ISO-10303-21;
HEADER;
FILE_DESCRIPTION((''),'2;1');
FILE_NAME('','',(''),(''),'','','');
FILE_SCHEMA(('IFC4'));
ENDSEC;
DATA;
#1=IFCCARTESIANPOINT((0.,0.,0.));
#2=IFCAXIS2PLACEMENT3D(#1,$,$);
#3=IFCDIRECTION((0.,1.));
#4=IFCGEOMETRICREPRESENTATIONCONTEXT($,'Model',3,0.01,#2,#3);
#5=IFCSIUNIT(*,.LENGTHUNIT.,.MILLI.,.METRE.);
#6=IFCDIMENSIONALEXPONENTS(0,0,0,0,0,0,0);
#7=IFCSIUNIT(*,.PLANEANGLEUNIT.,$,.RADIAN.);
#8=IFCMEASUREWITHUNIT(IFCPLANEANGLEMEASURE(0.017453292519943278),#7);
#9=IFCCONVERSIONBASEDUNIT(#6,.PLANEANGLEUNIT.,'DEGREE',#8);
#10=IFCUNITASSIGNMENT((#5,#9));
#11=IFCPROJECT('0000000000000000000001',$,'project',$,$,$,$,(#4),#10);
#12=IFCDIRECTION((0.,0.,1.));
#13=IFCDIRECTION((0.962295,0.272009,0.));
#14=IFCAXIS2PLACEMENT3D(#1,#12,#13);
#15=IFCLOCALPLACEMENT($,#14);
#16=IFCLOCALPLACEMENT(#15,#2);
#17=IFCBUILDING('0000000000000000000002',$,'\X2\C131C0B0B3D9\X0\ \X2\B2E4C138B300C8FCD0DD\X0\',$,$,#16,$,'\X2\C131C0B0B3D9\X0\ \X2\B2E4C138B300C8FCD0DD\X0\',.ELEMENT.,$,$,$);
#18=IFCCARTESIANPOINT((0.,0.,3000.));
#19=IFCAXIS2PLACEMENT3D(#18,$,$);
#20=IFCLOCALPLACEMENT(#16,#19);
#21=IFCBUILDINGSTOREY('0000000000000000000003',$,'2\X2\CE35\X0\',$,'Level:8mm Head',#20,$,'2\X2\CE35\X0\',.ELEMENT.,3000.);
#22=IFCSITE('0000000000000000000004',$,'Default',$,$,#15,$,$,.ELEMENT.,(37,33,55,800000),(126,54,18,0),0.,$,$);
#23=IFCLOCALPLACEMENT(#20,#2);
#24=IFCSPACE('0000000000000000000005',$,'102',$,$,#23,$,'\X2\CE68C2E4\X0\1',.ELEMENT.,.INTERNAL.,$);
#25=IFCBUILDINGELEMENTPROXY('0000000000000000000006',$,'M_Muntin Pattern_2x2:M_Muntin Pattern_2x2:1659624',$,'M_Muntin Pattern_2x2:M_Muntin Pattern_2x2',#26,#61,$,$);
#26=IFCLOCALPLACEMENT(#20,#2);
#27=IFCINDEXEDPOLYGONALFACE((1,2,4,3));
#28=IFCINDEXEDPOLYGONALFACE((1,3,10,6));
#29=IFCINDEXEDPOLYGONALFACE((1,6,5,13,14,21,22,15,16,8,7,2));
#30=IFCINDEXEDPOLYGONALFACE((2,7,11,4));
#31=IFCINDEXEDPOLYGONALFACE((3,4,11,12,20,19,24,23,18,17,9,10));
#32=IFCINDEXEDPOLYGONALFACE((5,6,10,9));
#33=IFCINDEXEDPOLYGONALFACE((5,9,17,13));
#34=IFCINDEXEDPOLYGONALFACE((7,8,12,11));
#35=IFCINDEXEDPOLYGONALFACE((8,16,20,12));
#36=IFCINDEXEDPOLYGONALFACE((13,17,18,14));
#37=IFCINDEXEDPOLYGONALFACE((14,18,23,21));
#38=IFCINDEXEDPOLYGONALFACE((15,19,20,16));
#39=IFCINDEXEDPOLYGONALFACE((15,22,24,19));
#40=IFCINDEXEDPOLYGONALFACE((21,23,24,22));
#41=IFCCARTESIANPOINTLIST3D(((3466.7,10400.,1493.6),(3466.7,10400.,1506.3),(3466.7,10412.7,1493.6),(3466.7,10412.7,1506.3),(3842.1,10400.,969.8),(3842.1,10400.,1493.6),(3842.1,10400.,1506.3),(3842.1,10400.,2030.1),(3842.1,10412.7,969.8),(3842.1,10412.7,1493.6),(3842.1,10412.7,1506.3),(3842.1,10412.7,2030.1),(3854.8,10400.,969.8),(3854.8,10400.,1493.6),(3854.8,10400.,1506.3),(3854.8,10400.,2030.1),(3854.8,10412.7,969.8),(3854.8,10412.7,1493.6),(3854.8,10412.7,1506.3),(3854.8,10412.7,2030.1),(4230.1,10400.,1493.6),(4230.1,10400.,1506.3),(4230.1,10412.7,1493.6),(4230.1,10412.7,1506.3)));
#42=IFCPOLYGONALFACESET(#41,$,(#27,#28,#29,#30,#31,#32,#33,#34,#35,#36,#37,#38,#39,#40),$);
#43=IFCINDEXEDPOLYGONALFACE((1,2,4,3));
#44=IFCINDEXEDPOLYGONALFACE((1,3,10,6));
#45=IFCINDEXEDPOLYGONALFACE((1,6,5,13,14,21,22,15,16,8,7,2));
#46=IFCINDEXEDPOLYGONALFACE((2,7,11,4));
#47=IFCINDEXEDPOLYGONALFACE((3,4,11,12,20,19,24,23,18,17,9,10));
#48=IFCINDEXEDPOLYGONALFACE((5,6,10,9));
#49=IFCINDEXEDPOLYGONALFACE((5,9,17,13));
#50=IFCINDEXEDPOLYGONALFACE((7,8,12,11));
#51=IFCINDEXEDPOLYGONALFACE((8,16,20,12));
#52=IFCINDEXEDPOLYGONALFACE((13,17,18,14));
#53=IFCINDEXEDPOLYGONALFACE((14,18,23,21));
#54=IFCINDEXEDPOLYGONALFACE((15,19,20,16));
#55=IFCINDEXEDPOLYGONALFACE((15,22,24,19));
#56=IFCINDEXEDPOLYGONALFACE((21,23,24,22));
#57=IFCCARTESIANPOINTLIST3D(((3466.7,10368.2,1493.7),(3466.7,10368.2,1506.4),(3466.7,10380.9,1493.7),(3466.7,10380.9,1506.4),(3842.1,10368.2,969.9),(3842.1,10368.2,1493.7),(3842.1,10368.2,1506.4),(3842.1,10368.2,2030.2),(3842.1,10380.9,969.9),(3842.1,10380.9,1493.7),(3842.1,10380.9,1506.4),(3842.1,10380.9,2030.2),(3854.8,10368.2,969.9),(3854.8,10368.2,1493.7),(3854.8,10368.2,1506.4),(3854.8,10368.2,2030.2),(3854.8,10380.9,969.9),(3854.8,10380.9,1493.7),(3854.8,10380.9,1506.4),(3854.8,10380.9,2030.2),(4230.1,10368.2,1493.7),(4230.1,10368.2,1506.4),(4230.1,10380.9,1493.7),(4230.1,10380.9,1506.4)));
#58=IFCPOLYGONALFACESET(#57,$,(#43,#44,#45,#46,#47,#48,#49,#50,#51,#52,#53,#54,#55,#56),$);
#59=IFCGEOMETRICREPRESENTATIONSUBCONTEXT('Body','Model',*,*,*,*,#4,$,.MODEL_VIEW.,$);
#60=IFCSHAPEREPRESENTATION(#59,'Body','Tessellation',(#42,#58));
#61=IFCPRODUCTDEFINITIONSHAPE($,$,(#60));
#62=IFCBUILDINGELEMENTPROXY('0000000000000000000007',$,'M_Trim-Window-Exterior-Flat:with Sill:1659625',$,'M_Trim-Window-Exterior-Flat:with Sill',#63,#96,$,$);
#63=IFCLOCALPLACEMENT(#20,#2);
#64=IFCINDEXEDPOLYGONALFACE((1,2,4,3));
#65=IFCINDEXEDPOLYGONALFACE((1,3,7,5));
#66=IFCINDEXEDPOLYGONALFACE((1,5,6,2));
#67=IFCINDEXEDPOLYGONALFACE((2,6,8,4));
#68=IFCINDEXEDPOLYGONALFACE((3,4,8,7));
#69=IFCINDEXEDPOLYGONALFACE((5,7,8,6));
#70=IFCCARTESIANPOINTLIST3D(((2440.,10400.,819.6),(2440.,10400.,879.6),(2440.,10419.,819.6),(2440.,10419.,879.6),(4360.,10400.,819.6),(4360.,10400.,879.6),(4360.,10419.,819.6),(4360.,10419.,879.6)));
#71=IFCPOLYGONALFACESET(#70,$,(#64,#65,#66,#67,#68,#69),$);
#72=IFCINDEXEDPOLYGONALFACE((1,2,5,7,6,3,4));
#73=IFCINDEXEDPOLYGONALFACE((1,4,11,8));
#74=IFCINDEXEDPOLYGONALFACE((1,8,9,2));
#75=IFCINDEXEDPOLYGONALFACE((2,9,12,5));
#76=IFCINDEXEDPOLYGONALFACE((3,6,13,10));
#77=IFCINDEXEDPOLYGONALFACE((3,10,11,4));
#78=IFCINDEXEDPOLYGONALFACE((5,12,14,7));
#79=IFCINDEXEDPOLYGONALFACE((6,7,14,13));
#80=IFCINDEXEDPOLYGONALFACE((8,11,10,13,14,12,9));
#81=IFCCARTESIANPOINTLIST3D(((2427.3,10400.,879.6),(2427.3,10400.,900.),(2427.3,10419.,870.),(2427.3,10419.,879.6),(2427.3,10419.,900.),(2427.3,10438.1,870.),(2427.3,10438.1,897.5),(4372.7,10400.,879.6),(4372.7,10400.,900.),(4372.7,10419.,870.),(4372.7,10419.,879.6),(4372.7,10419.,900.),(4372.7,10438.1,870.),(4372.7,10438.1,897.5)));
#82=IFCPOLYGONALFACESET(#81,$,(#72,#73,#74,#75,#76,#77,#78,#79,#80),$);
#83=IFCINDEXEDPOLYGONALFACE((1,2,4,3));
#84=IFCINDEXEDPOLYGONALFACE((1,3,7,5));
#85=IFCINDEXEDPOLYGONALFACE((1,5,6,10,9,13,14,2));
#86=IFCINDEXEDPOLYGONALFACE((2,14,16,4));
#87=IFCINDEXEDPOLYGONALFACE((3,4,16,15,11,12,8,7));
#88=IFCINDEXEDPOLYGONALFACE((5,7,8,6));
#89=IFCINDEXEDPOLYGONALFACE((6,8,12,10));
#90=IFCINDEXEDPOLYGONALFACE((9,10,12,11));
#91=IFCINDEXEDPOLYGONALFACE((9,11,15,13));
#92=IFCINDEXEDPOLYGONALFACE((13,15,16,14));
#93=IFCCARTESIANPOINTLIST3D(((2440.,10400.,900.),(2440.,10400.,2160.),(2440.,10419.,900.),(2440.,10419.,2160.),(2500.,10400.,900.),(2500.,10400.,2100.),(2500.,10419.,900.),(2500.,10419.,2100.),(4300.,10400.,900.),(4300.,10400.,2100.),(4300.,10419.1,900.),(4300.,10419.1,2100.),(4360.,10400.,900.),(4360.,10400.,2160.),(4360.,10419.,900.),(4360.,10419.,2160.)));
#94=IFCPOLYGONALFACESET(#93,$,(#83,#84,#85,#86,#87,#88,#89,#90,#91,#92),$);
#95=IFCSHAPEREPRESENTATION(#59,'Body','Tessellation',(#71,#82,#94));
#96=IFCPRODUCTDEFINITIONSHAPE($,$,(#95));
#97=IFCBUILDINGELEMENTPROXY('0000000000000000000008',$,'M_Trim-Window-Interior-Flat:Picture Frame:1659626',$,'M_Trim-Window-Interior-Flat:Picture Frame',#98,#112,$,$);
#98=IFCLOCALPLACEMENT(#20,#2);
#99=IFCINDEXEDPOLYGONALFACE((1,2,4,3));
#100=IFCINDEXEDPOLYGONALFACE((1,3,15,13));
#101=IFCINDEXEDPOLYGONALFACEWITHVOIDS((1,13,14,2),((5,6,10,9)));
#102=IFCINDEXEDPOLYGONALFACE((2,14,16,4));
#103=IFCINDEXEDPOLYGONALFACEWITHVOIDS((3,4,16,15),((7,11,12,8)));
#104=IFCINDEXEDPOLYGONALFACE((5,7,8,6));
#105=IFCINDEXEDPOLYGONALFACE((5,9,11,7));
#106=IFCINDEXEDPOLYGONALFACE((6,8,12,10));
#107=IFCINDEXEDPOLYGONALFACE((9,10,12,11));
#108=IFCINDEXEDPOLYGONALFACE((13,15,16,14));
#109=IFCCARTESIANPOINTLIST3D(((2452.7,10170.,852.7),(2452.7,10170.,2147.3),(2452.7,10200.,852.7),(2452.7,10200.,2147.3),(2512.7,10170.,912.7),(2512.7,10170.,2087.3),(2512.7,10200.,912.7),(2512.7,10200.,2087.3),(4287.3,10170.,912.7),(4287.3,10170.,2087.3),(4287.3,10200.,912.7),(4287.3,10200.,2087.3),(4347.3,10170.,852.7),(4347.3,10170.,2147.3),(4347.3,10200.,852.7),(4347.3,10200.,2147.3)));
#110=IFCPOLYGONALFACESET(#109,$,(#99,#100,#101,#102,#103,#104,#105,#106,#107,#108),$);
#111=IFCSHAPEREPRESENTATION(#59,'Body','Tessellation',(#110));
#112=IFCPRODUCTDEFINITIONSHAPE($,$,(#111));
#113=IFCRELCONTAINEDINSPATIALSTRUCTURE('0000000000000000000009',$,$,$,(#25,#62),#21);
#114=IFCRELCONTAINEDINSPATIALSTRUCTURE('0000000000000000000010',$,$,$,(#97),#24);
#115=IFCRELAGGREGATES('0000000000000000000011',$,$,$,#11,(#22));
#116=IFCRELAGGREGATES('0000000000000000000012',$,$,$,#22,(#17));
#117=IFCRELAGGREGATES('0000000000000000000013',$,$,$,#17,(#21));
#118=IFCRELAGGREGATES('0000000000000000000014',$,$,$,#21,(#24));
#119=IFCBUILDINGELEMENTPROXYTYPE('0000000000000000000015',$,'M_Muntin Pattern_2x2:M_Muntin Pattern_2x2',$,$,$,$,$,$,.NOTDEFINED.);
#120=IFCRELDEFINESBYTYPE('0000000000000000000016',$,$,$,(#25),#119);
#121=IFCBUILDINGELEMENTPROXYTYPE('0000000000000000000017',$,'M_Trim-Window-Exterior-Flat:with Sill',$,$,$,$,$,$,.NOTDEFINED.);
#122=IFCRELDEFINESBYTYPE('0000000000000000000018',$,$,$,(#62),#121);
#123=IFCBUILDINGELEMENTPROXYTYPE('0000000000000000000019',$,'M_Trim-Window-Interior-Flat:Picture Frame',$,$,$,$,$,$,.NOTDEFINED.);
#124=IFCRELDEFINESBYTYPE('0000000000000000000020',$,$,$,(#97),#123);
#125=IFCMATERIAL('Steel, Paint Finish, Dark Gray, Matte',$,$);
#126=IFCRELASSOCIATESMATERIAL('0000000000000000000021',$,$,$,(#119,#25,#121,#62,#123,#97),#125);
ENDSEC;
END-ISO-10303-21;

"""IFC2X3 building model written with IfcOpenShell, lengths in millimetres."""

from ifc_helpers import new_model, entity, si_unit, converted_unit, direction, frame, frame_2d, origin, place, context, subcontext, project, spatial, polyline, rectangle, outline, extrude, source, transform, mapped, material, type_object, type_shapes, element, save


model = new_model("IFC2X3")

# Units and contexts
model_context = context("Model", 3, precision=0.01, world=origin(), true_north=direction((0.0, 1.0)))
body_context = subcontext(model_context, "Body", "Model", "MODEL_VIEW")
ifc_project = project(units=[si_unit("LENGTHUNIT", "METRE", prefix="MILLI"), converted_unit("PLANEANGLEUNIT", "DEGREE", entity("IfcPlaneAngleMeasure", 0.017453292519943278), si_unit("PLANEANGLEUNIT", "RADIAN"), dimensions=[0, 0, 0, 0, 0, 0, 0])], contexts=[model_context])

# Site, building, storey
site_placement = place(None, frame((0.0, 0.0, 0.0), z_axis=(0.0, 0.0, 1.0), x_axis=(0.962295, 0.272009, 0.0)))
site = spatial("IfcSite", under=ifc_project, at=site_placement, Name="Default", CompositionType="ELEMENT", RefLatitude=(37, 33, 55, 800000), RefLongitude=(126, 54, 18, 0), RefElevation=0.0)
building_placement = place(site_placement, origin())
building = spatial("IfcBuilding", under=site, at=building_placement, Name="성산동 다세대주택", LongName="성산동 다세대주택", CompositionType="ELEMENT")
storey_placement = place(building_placement, frame((0.0, 0.0, 3000.0)))
storey = spatial("IfcBuildingStorey", under=building, at=storey_placement, Name="2층", ObjectType="Level:8mm Head", LongName="2층", CompositionType="ELEMENT", Elevation=3000.0)

# Shared definitions
space_1_placement = place(storey_placement, origin())
space_1 = spatial("IfcSpace", under=storey, at=space_1_placement, Name="102", LongName="침실1", CompositionType="ELEMENT", InteriorOrExteriorSpace="INTERNAL")

# Building element proxies
ifc_material_1 = material(Name="Steel, Paint Finish, Dark Gray, Matte")
building_element_proxy_type_1 = type_object("IfcBuildingElementProxyType", Name="M_Muntin Pattern_2x2:M_Muntin Pattern_2x2", PredefinedType="NOTDEFINED", material=ifc_material_1)
shared_shape_1 = source(origin(), body_context, "Body", "SweptSolid", [
    extrude(outline(polyline([(6.4, -6.4), (530.1, -6.4), (530.1, 6.3), (6.4, 6.3), (6.4, 381.7), (-6.3, 381.7), (-6.3, 6.3), (-530.2, 6.3), (-530.2, -6.4), (-6.3, -6.4), (-6.3, -381.7), (6.4, -381.7), (6.4, -6.4)])), frame((0.0, -22.2, 530.1), z_axis=(0.0, 1.0, 0.0), x_axis=(0.0, 0.0, 1.0)), (0.0, 0.0, 1.0), 12.7),
    extrude(outline(polyline([(6.4, -6.4), (530.2, -6.4), (530.2, 6.3), (6.4, 6.3), (6.4, 381.7), (-6.3, 381.7), (-6.3, 6.3), (-530.2, 6.3), (-530.2, -6.4), (-6.3, -6.4), (-6.3, -381.7), (6.4, -381.7), (6.4, -6.4)])), frame((0.0, 9.5, 530.2), z_axis=(0.0, 1.0, 0.0), x_axis=(0.0, 0.0, 1.0)), (0.0, 0.0, 1.0), 12.7),
])
type_shapes(building_element_proxy_type_1, [shared_shape_1])
proxy_1_placement = place(storey_placement, frame((3848.4, 10390.5, 969.9), z_axis=(0.0, 0.0, 1.0), x_axis=(-1.0, 0.0, 0.0)))
element("IfcBuildingElementProxy", 1, at=proxy_1_placement, inside=storey, type_object=building_element_proxy_type_1, material=ifc_material_1, Name="M_Muntin Pattern_2x2:M_Muntin Pattern_2x2:1659624", ObjectType="M_Muntin Pattern_2x2:M_Muntin Pattern_2x2", context=body_context, shape_type="MappedRepresentation", body=[
    mapped(shared_shape_1, transform((0.0, 0.0, 0.0), scale=1.0)),
])
building_element_proxy_type_2 = type_object("IfcBuildingElementProxyType", Name="M_Trim-Window-Exterior-Flat:with Sill", PredefinedType="NOTDEFINED", material=ifc_material_1)
shared_shape_2 = source(origin(), body_context, "Body", "SweptSolid", [
    extrude(rectangle(XDim=1920.0, YDim=60.0, at=frame_2d((0.0, 0.0), x_axis=(1.0, 0.0))), frame((0.0, -1250.4, 0.0), z_axis=(0.0, 0.0, 1.0), x_axis=(-1.0, 0.0, 0.0)), (0.0, 0.0, 1.0), 19.0),
    extrude(outline(polyline([(-19.0, -15.2), (0.0, -15.2), (0.0, -5.7), (19.0, -5.7), (19.0, 14.8), (0.0, 14.8), (-19.0, 12.3), (-19.0, -15.2)])), frame((-972.7, -1214.8, 19.0), z_axis=(1.0, 0.0, 0.0), x_axis=(0.0, 0.0, -1.0)), (0.0, 0.0, 1.0), 1945.4),
    extrude(outline(polyline([(-645.0, -960.0), (615.0, -960.0), (615.0, -900.0), (-585.0, -900.0), (-585.0, 900.0), (615.0, 900.0), (615.0, 960.0), (-645.0, 960.0), (-645.0, -960.0)])), frame((0.0, -585.0, 0.0), z_axis=(0.0, 0.0, 1.0), x_axis=(0.0, -1.0, 0.0)), (0.0, 0.0, 1.0), 19.0),
])
type_shapes(building_element_proxy_type_2, [shared_shape_2])
proxy_2_placement = place(storey_placement, frame((3400.0, 10400.0, 2100.0), z_axis=(0.0, 1.0, 0.0), x_axis=(-1.0, 0.0, 0.0)))
element("IfcBuildingElementProxy", 2, at=proxy_2_placement, inside=storey, type_object=building_element_proxy_type_2, material=ifc_material_1, Name="M_Trim-Window-Exterior-Flat:with Sill:1659625", ObjectType="M_Trim-Window-Exterior-Flat:with Sill", context=body_context, shape_type="MappedRepresentation", body=[
    mapped(shared_shape_2, transform((0.0, 0.0, 0.0), scale=1.0)),
])
building_element_proxy_type_3 = type_object("IfcBuildingElementProxyType", Name="M_Trim-Window-Interior-Flat:Picture Frame", PredefinedType="NOTDEFINED", material=ifc_material_1)
shared_shape_3 = source(origin(), body_context, "Body", "SweptSolid", [
    extrude(outline(polyline([(-947.3, -647.3), (947.3, -647.3), (947.3, 647.3), (-947.3, 647.3), (-947.3, -647.3)]), holes=[polyline([(-887.3, -587.3), (-887.3, 587.3), (887.3, 587.3), (887.3, -587.3), (-887.3, -587.3)])]), frame((0.0, -600.0, 0.0), z_axis=(0.0, 0.0, 1.0), x_axis=(-1.0, 0.0, 0.0)), (0.0, 0.0, 1.0), 30.0),
])
type_shapes(building_element_proxy_type_3, [shared_shape_3])
proxy_3_placement = place(space_1_placement, frame((3400.0, 10200.0, 2100.0), z_axis=(0.0, -1.0, 0.0), x_axis=(1.0, 0.0, 0.0)))
element("IfcBuildingElementProxy", 3, at=proxy_3_placement, inside=space_1, type_object=building_element_proxy_type_3, material=ifc_material_1, Name="M_Trim-Window-Interior-Flat:Picture Frame:1659626", ObjectType="M_Trim-Window-Interior-Flat:Picture Frame", context=body_context, shape_type="MappedRepresentation", body=[
    mapped(shared_shape_3, transform((0.0, 0.0, 0.0), scale=1.0)),
])

save(model, "model.ifc")
